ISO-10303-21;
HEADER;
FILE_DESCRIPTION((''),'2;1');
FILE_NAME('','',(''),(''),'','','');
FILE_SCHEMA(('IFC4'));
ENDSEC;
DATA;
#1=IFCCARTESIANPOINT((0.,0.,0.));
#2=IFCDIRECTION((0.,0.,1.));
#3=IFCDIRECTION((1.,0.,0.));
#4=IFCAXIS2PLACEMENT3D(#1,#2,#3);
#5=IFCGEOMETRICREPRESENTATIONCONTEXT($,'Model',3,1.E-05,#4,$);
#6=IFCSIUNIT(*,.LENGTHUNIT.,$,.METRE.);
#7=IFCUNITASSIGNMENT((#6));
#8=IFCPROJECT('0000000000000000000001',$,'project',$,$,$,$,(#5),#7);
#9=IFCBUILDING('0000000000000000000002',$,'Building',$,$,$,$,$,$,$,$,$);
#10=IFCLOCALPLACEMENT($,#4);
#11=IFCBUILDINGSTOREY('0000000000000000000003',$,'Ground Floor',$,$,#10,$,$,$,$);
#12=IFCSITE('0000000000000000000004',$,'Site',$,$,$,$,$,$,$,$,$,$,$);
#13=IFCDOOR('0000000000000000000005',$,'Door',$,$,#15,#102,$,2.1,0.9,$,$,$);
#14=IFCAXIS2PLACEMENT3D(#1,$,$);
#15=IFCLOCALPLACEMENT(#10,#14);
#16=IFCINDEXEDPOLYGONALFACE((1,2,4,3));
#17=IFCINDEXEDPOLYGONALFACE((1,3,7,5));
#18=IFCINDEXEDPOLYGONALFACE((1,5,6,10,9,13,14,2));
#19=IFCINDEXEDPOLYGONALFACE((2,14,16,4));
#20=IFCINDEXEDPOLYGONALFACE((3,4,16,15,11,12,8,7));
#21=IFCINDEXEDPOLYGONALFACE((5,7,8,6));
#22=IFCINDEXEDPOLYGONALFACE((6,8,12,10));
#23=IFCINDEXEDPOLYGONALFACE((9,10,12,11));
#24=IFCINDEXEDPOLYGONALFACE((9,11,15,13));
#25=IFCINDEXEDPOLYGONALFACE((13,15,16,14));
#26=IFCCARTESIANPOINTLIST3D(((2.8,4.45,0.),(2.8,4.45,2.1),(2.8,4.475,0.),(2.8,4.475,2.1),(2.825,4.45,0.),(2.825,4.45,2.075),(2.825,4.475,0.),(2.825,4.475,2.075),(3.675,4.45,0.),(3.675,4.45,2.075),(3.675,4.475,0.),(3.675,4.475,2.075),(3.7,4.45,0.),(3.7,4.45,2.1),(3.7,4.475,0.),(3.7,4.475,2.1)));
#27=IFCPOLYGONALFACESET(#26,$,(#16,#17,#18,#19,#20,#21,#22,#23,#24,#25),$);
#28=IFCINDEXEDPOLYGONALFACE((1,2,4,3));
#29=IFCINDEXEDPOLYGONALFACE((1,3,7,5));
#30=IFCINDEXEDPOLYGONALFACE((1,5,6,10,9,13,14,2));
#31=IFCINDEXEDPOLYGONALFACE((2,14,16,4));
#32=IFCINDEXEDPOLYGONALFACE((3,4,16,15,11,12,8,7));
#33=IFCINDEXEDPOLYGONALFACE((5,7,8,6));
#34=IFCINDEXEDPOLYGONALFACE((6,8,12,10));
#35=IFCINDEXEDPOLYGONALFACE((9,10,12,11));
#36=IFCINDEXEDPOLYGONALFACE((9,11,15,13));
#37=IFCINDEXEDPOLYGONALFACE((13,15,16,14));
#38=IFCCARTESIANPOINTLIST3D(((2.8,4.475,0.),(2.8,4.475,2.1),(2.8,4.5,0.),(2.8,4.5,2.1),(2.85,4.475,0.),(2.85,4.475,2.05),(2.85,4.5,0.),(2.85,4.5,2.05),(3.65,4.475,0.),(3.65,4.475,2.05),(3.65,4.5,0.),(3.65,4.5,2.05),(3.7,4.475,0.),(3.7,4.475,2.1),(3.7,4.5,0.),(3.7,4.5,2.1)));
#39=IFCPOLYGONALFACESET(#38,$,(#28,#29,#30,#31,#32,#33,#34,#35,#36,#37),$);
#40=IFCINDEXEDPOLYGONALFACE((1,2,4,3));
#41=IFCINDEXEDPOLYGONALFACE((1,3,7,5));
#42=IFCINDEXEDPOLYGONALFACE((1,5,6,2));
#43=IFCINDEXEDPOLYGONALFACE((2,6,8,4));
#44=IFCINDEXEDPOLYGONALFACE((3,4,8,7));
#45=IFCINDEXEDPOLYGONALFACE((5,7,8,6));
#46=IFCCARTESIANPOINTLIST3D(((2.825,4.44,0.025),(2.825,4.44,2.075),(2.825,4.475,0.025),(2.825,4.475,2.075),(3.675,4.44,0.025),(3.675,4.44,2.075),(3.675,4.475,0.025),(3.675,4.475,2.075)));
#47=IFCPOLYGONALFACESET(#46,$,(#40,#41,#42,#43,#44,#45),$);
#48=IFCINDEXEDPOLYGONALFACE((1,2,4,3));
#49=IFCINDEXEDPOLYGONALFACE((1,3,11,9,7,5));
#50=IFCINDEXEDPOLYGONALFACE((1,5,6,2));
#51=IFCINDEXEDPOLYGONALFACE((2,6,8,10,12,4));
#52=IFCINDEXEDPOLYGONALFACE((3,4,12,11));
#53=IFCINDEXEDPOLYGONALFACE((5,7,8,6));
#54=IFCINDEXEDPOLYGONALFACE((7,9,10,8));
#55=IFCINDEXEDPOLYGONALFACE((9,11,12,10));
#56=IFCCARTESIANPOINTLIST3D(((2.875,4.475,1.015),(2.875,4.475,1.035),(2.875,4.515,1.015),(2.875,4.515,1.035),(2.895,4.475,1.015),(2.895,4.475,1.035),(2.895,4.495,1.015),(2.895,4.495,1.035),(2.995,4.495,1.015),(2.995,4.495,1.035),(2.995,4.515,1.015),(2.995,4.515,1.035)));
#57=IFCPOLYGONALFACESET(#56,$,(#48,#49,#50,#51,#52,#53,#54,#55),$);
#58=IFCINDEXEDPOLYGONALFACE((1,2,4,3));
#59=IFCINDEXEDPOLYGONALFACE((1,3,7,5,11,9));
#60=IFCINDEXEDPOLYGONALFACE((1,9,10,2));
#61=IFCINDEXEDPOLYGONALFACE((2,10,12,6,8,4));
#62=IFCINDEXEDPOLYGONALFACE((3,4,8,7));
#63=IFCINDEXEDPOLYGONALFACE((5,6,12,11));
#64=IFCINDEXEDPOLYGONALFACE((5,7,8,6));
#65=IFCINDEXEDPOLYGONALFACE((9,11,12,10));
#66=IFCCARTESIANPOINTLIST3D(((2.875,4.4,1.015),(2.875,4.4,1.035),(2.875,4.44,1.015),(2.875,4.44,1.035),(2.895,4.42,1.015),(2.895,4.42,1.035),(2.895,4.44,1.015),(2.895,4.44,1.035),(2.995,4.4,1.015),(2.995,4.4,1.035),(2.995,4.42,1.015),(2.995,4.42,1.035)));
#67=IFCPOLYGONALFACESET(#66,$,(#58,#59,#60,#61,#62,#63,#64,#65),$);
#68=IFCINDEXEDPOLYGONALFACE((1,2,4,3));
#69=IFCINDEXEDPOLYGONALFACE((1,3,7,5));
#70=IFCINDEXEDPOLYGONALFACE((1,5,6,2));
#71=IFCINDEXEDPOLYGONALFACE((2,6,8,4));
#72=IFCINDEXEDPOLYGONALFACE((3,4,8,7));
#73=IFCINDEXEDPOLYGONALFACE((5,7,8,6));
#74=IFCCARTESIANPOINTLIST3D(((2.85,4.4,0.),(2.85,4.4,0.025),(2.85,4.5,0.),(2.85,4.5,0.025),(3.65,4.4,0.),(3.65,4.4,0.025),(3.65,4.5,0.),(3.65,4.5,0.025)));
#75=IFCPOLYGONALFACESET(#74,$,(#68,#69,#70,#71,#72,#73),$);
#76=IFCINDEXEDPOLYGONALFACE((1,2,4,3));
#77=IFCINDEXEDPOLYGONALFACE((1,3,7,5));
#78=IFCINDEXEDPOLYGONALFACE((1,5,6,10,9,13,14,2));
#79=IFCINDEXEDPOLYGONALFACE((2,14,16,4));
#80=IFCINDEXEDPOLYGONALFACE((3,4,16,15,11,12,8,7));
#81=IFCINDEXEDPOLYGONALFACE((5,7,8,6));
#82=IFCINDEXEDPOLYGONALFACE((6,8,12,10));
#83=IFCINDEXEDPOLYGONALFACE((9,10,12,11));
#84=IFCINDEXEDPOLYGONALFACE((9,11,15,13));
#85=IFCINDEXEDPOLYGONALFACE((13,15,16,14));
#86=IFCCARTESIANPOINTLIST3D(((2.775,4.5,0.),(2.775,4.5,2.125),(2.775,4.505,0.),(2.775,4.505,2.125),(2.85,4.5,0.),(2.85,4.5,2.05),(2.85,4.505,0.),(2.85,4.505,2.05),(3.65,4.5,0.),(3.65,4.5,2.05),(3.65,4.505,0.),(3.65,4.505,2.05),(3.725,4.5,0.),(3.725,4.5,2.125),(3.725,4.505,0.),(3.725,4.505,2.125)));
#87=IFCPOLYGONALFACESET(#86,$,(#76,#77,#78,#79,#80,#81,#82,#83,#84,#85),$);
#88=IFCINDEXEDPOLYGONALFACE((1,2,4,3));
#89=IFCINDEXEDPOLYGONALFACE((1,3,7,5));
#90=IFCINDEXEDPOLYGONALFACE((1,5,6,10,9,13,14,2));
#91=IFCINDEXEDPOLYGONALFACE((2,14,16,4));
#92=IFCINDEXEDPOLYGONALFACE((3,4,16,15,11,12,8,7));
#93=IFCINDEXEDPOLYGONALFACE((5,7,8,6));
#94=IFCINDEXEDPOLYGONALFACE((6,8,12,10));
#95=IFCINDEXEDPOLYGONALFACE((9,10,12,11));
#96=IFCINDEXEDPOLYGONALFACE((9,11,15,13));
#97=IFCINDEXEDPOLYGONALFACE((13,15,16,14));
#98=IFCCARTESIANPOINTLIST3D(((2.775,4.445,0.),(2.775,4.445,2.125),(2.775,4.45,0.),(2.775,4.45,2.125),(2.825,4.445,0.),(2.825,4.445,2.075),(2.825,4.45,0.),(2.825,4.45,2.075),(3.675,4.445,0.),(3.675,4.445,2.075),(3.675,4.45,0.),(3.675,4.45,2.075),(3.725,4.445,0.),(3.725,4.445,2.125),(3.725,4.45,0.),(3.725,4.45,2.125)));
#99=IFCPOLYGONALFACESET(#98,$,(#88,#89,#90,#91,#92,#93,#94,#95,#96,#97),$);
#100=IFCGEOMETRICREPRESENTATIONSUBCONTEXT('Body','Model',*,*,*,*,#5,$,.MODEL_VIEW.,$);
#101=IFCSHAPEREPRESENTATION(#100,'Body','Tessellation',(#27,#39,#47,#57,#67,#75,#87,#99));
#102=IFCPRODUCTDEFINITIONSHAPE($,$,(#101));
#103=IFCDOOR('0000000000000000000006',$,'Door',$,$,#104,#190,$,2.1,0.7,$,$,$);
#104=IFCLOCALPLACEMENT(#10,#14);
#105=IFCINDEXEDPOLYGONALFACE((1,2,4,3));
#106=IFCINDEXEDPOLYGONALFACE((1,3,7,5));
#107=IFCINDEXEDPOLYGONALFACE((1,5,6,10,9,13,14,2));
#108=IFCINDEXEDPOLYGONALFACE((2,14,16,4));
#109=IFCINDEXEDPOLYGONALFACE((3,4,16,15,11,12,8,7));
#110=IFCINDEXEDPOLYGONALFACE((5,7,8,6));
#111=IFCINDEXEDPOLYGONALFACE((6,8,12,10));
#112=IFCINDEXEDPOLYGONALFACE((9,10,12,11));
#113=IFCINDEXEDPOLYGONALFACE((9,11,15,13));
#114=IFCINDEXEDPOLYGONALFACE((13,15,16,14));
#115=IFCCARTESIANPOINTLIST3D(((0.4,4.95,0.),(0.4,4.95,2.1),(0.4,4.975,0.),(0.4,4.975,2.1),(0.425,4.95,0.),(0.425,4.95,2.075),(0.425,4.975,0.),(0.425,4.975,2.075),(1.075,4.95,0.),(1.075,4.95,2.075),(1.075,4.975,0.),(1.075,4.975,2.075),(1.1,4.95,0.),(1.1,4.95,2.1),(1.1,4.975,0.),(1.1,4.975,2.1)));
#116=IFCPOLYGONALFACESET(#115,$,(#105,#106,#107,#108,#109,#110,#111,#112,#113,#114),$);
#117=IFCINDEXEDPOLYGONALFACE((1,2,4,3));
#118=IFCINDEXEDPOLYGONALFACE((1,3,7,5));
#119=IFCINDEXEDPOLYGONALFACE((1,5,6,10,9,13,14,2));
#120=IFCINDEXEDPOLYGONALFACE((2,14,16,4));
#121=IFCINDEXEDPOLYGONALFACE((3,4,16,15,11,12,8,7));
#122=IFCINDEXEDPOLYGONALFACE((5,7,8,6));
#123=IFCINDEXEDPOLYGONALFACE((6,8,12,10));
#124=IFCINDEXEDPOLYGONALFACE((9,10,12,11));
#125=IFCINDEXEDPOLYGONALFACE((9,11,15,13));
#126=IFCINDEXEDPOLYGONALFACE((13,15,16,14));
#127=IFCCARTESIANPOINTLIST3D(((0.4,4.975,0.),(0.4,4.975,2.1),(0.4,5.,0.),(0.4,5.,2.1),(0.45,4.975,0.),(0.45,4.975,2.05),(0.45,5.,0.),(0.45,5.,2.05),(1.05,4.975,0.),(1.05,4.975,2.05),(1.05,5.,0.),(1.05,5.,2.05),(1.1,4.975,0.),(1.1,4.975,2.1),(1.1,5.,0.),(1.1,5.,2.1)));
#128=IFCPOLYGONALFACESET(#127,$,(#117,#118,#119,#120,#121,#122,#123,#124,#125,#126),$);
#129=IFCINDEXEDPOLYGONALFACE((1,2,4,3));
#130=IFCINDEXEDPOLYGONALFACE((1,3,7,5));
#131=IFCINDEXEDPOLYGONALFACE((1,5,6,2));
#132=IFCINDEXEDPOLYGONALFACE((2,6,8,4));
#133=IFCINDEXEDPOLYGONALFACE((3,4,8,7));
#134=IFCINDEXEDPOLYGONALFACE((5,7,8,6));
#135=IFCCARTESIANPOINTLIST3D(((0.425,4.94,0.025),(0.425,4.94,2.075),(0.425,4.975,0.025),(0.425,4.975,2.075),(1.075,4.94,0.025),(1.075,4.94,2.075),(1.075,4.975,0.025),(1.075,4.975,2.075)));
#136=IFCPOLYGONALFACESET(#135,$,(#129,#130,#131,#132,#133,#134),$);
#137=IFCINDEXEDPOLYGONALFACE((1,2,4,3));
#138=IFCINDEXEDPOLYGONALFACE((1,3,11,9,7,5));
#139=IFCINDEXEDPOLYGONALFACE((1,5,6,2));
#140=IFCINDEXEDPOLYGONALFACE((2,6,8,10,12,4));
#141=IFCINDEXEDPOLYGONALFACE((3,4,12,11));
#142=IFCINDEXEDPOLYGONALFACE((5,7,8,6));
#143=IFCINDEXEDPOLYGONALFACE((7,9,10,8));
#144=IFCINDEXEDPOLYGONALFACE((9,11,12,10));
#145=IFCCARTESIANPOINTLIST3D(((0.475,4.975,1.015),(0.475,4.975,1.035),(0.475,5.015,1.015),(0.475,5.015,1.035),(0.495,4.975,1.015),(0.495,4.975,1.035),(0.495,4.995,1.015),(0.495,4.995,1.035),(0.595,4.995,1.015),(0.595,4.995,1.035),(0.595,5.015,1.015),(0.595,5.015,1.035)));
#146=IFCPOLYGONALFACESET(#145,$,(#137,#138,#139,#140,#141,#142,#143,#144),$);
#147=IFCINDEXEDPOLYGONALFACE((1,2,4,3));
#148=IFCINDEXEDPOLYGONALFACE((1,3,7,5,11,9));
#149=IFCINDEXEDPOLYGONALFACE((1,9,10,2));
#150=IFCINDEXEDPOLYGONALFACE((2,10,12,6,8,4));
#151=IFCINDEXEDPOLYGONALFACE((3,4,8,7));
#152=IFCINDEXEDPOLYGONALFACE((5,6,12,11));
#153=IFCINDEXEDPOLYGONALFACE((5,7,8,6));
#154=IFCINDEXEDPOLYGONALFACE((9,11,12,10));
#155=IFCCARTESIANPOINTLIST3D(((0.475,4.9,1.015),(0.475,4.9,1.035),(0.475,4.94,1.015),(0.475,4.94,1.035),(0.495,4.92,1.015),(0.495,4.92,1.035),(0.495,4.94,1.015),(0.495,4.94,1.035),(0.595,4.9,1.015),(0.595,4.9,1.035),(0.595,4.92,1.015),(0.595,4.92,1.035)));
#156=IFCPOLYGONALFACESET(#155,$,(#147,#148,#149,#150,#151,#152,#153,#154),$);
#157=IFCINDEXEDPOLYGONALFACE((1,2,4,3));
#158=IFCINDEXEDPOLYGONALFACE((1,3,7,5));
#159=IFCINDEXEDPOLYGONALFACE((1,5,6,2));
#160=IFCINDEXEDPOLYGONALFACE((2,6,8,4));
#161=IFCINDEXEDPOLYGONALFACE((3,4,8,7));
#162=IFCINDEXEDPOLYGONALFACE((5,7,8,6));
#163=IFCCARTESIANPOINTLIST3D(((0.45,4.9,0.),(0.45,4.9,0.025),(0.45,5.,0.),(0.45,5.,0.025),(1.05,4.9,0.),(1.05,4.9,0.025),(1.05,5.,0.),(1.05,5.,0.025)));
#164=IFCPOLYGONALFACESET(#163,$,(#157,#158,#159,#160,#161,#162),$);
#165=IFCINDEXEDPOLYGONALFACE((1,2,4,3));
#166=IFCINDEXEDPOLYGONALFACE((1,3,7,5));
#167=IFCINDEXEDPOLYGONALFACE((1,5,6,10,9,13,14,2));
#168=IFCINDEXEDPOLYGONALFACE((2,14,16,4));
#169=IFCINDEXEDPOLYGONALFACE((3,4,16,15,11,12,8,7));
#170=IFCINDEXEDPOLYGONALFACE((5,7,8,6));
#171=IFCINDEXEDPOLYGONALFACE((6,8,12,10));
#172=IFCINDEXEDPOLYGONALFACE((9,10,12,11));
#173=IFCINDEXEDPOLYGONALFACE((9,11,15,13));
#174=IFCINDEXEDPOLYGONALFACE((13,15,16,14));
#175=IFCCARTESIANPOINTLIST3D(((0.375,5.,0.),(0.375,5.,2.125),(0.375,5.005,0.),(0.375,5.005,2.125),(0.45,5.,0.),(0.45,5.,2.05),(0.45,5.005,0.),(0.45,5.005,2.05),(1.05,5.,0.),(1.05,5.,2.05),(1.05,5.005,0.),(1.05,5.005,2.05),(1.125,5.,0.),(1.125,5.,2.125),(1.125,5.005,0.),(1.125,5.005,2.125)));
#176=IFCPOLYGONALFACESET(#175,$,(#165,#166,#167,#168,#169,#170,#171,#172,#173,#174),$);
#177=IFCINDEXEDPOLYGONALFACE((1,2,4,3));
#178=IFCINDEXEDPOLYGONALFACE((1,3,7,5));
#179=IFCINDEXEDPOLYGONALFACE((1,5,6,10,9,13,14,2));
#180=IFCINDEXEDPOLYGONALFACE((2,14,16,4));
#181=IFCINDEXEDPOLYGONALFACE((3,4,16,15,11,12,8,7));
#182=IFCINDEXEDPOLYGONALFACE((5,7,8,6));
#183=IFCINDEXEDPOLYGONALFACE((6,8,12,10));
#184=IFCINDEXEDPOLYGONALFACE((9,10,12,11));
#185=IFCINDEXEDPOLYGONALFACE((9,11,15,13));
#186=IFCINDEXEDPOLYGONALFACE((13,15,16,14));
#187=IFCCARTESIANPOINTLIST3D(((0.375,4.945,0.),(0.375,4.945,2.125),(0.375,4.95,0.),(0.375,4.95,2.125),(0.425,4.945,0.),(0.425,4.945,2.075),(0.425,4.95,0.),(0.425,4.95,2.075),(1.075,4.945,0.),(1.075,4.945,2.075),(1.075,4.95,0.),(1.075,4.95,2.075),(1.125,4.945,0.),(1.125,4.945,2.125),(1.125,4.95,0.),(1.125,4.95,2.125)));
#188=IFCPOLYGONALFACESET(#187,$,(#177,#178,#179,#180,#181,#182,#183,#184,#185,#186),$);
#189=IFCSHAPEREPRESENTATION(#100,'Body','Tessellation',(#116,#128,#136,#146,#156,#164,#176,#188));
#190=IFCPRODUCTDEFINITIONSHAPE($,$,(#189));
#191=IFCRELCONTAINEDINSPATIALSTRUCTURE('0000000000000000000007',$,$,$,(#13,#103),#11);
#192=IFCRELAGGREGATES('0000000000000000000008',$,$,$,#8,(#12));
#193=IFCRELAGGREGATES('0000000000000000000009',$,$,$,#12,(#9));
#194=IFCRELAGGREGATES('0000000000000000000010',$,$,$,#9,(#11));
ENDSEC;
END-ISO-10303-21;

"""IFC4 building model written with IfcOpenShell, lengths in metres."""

from ifc_helpers import new_model, si_unit, frame, origin_with_axes, place, context, subcontext, project, spatial, line, indexed_curve, outline, extrude, element, save


model = new_model("IFC4")

# Units and contexts
model_context = context("Model", 3, precision=1e-05, world=origin_with_axes())
body_context = subcontext(model_context, "Body", "Model", "MODEL_VIEW")
ifc_project = project(units=[si_unit("LENGTHUNIT", "METRE")], contexts=[model_context])

# Site, building, storey
site = spatial("IfcSite", under=ifc_project, Name="Site")
building = spatial("IfcBuilding", under=site, Name="Building")
storey_placement = place(None, origin_with_axes())
storey = spatial("IfcBuildingStorey", under=building, at=storey_placement, Name="Ground Floor")

# Doors
door_1_placement = place(storey_placement, frame((3.7, 4.5, 0.0), z_axis=(0.0, 0.0, 1.0), x_axis=(-1.0, 0.0, 0.0)))
element("IfcDoor", 1, at=door_1_placement, inside=storey, Name="Door", OverallHeight=2.1, OverallWidth=0.9, context=body_context, shape_type="SweptSolid", body=[
    extrude(outline(indexed_curve([(0.0, 0.0), (0.0, 2.1), (0.9, 2.1), (0.9, 0.0), (0.875, 0.0), (0.875, 2.075), (0.025, 2.075), (0.025, 0.0)], segments=[line(1, 2, 3, 4, 5, 6, 7, 8, 1)])), frame((0.0, 0.025, 0.0), z_axis=(0.0, -1.0, 0.0), x_axis=(1.0, 0.0, 0.0)), (0.0, 0.0, -1.0), 0.025),
    extrude(outline(indexed_curve([(0.0, 0.0), (0.0, 2.1), (0.9, 2.1), (0.9, 0.0), (0.85, 0.0), (0.85, 2.05), (0.05, 2.05), (0.05, 0.0)], segments=[line(1, 2, 3, 4, 5, 6, 7, 8, 1)])), frame((0.0, 0.0, 0.0), z_axis=(0.0, -1.0, 0.0), x_axis=(1.0, 0.0, 0.0)), (0.0, 0.0, -1.0), 0.025),
    extrude(outline(indexed_curve([(0.0, 0.0), (0.85, 0.0), (0.85, 0.035), (0.0, 0.035)], segments=[line(1, 2, 3, 4, 1)])), frame((0.025, 0.025, 0.025), z_axis=(0.0, 0.0, 1.0), x_axis=(1.0, 0.0, 0.0)), (0.0, 0.0, 1.0), 2.05),
    extrude(outline(indexed_curve([(0.0, 0.0), (0.0, -0.04), (-0.12, -0.04), (-0.12, -0.02), (-0.02, -0.02), (-0.02, 0.0)], segments=[line(1, 2, 3, 4, 5, 6, 1)])), frame((0.825, 0.025, 1.015), z_axis=(0.0, 0.0, 1.0), x_axis=(1.0, 0.0, 0.0)), (0.0, 0.0, 1.0), 0.02),
    extrude(outline(indexed_curve([(0.0, 0.0), (0.0, 0.04), (-0.12, 0.04), (-0.12, 0.02), (-0.02, 0.02), (-0.02, 0.0)], segments=[line(1, 2, 3, 4, 5, 6, 1)])), frame((0.825, 0.06, 1.015), z_axis=(0.0, 0.0, 1.0), x_axis=(1.0, 0.0, 0.0)), (0.0, 0.0, 1.0), 0.02),
    extrude(outline(indexed_curve([(0.0, 0.0), (0.8, 0.0), (0.8, 0.1), (0.0, 0.1)], segments=[line(1, 2, 3, 4, 1)])), frame((0.05, 0.0, 0.0), z_axis=(0.0, 0.0, 1.0), x_axis=(1.0, 0.0, 0.0)), (0.0, 0.0, 1.0), 0.025),
    extrude(outline(indexed_curve([(0.0, 0.0), (0.0, 2.125), (0.95, 2.125), (0.95, 0.0), (0.875, 0.0), (0.875, 2.05), (0.075, 2.05), (0.075, 0.0)], segments=[line(1, 2, 3, 4, 5, 6, 7, 8, 1)])), frame((-0.025, -0.005, 0.0), z_axis=(0.0, -1.0, 0.0), x_axis=(1.0, 0.0, 0.0)), (0.0, 0.0, -1.0), 0.005),
    extrude(outline(indexed_curve([(0.0, 0.0), (0.0, 2.125), (0.95, 2.125), (0.95, 0.0), (0.9, 0.0), (0.9, 2.075), (0.05, 2.075), (0.05, 0.0)], segments=[line(1, 2, 3, 4, 5, 6, 7, 8, 1)])), frame((-0.025, 0.05, 0.0), z_axis=(0.0, -1.0, 0.0), x_axis=(1.0, 0.0, 0.0)), (0.0, 0.0, -1.0), 0.005),
])
door_2_placement = place(storey_placement, frame((1.1, 5.0, 0.0), z_axis=(0.0, 0.0, 1.0), x_axis=(-1.0, 0.0, 0.0)))
element("IfcDoor", 2, at=door_2_placement, inside=storey, Name="Door", OverallHeight=2.1, OverallWidth=0.7, context=body_context, shape_type="SweptSolid", body=[
    extrude(outline(indexed_curve([(0.0, 0.0), (0.0, 2.1), (0.7, 2.1), (0.7, 0.0), (0.675, 0.0), (0.675, 2.075), (0.025, 2.075), (0.025, 0.0)], segments=[line(1, 2, 3, 4, 5, 6, 7, 8, 1)])), frame((0.0, 0.025, 0.0), z_axis=(0.0, -1.0, 0.0), x_axis=(1.0, 0.0, 0.0)), (0.0, 0.0, -1.0), 0.025),
    extrude(outline(indexed_curve([(0.0, 0.0), (0.0, 2.1), (0.7, 2.1), (0.7, 0.0), (0.65, 0.0), (0.65, 2.05), (0.05, 2.05), (0.05, 0.0)], segments=[line(1, 2, 3, 4, 5, 6, 7, 8, 1)])), frame((0.0, 0.0, 0.0), z_axis=(0.0, -1.0, 0.0), x_axis=(1.0, 0.0, 0.0)), (0.0, 0.0, -1.0), 0.025),
    extrude(outline(indexed_curve([(0.0, 0.0), (0.65, 0.0), (0.65, 0.035), (0.0, 0.035)], segments=[line(1, 2, 3, 4, 1)])), frame((0.025, 0.025, 0.025), z_axis=(0.0, 0.0, 1.0), x_axis=(1.0, 0.0, 0.0)), (0.0, 0.0, 1.0), 2.05),
    extrude(outline(indexed_curve([(0.0, 0.0), (0.0, -0.04), (-0.12, -0.04), (-0.12, -0.02), (-0.02, -0.02), (-0.02, 0.0)], segments=[line(1, 2, 3, 4, 5, 6, 1)])), frame((0.625, 0.025, 1.015), z_axis=(0.0, 0.0, 1.0), x_axis=(1.0, 0.0, 0.0)), (0.0, 0.0, 1.0), 0.02),
    extrude(outline(indexed_curve([(0.0, 0.0), (0.0, 0.04), (-0.12, 0.04), (-0.12, 0.02), (-0.02, 0.02), (-0.02, 0.0)], segments=[line(1, 2, 3, 4, 5, 6, 1)])), frame((0.625, 0.06, 1.015), z_axis=(0.0, 0.0, 1.0), x_axis=(1.0, 0.0, 0.0)), (0.0, 0.0, 1.0), 0.02),
    extrude(outline(indexed_curve([(0.0, 0.0), (0.6, 0.0), (0.6, 0.1), (0.0, 0.1)], segments=[line(1, 2, 3, 4, 1)])), frame((0.05, 0.0, 0.0), z_axis=(0.0, 0.0, 1.0), x_axis=(1.0, 0.0, 0.0)), (0.0, 0.0, 1.0), 0.025),
    extrude(outline(indexed_curve([(0.0, 0.0), (0.0, 2.125), (0.75, 2.125), (0.75, 0.0), (0.675, 0.0), (0.675, 2.05), (0.075, 2.05), (0.075, 0.0)], segments=[line(1, 2, 3, 4, 5, 6, 7, 8, 1)])), frame((-0.025, -0.005, 0.0), z_axis=(0.0, -1.0, 0.0), x_axis=(1.0, 0.0, 0.0)), (0.0, 0.0, -1.0), 0.005),
    extrude(outline(indexed_curve([(0.0, 0.0), (0.0, 2.125), (0.75, 2.125), (0.75, 0.0), (0.7, 0.0), (0.7, 2.075), (0.05, 2.075), (0.05, 0.0)], segments=[line(1, 2, 3, 4, 5, 6, 7, 8, 1)])), frame((-0.025, 0.05, 0.0), z_axis=(0.0, -1.0, 0.0), x_axis=(1.0, 0.0, 0.0)), (0.0, 0.0, -1.0), 0.005),
])

save(model, "model.ifc")
